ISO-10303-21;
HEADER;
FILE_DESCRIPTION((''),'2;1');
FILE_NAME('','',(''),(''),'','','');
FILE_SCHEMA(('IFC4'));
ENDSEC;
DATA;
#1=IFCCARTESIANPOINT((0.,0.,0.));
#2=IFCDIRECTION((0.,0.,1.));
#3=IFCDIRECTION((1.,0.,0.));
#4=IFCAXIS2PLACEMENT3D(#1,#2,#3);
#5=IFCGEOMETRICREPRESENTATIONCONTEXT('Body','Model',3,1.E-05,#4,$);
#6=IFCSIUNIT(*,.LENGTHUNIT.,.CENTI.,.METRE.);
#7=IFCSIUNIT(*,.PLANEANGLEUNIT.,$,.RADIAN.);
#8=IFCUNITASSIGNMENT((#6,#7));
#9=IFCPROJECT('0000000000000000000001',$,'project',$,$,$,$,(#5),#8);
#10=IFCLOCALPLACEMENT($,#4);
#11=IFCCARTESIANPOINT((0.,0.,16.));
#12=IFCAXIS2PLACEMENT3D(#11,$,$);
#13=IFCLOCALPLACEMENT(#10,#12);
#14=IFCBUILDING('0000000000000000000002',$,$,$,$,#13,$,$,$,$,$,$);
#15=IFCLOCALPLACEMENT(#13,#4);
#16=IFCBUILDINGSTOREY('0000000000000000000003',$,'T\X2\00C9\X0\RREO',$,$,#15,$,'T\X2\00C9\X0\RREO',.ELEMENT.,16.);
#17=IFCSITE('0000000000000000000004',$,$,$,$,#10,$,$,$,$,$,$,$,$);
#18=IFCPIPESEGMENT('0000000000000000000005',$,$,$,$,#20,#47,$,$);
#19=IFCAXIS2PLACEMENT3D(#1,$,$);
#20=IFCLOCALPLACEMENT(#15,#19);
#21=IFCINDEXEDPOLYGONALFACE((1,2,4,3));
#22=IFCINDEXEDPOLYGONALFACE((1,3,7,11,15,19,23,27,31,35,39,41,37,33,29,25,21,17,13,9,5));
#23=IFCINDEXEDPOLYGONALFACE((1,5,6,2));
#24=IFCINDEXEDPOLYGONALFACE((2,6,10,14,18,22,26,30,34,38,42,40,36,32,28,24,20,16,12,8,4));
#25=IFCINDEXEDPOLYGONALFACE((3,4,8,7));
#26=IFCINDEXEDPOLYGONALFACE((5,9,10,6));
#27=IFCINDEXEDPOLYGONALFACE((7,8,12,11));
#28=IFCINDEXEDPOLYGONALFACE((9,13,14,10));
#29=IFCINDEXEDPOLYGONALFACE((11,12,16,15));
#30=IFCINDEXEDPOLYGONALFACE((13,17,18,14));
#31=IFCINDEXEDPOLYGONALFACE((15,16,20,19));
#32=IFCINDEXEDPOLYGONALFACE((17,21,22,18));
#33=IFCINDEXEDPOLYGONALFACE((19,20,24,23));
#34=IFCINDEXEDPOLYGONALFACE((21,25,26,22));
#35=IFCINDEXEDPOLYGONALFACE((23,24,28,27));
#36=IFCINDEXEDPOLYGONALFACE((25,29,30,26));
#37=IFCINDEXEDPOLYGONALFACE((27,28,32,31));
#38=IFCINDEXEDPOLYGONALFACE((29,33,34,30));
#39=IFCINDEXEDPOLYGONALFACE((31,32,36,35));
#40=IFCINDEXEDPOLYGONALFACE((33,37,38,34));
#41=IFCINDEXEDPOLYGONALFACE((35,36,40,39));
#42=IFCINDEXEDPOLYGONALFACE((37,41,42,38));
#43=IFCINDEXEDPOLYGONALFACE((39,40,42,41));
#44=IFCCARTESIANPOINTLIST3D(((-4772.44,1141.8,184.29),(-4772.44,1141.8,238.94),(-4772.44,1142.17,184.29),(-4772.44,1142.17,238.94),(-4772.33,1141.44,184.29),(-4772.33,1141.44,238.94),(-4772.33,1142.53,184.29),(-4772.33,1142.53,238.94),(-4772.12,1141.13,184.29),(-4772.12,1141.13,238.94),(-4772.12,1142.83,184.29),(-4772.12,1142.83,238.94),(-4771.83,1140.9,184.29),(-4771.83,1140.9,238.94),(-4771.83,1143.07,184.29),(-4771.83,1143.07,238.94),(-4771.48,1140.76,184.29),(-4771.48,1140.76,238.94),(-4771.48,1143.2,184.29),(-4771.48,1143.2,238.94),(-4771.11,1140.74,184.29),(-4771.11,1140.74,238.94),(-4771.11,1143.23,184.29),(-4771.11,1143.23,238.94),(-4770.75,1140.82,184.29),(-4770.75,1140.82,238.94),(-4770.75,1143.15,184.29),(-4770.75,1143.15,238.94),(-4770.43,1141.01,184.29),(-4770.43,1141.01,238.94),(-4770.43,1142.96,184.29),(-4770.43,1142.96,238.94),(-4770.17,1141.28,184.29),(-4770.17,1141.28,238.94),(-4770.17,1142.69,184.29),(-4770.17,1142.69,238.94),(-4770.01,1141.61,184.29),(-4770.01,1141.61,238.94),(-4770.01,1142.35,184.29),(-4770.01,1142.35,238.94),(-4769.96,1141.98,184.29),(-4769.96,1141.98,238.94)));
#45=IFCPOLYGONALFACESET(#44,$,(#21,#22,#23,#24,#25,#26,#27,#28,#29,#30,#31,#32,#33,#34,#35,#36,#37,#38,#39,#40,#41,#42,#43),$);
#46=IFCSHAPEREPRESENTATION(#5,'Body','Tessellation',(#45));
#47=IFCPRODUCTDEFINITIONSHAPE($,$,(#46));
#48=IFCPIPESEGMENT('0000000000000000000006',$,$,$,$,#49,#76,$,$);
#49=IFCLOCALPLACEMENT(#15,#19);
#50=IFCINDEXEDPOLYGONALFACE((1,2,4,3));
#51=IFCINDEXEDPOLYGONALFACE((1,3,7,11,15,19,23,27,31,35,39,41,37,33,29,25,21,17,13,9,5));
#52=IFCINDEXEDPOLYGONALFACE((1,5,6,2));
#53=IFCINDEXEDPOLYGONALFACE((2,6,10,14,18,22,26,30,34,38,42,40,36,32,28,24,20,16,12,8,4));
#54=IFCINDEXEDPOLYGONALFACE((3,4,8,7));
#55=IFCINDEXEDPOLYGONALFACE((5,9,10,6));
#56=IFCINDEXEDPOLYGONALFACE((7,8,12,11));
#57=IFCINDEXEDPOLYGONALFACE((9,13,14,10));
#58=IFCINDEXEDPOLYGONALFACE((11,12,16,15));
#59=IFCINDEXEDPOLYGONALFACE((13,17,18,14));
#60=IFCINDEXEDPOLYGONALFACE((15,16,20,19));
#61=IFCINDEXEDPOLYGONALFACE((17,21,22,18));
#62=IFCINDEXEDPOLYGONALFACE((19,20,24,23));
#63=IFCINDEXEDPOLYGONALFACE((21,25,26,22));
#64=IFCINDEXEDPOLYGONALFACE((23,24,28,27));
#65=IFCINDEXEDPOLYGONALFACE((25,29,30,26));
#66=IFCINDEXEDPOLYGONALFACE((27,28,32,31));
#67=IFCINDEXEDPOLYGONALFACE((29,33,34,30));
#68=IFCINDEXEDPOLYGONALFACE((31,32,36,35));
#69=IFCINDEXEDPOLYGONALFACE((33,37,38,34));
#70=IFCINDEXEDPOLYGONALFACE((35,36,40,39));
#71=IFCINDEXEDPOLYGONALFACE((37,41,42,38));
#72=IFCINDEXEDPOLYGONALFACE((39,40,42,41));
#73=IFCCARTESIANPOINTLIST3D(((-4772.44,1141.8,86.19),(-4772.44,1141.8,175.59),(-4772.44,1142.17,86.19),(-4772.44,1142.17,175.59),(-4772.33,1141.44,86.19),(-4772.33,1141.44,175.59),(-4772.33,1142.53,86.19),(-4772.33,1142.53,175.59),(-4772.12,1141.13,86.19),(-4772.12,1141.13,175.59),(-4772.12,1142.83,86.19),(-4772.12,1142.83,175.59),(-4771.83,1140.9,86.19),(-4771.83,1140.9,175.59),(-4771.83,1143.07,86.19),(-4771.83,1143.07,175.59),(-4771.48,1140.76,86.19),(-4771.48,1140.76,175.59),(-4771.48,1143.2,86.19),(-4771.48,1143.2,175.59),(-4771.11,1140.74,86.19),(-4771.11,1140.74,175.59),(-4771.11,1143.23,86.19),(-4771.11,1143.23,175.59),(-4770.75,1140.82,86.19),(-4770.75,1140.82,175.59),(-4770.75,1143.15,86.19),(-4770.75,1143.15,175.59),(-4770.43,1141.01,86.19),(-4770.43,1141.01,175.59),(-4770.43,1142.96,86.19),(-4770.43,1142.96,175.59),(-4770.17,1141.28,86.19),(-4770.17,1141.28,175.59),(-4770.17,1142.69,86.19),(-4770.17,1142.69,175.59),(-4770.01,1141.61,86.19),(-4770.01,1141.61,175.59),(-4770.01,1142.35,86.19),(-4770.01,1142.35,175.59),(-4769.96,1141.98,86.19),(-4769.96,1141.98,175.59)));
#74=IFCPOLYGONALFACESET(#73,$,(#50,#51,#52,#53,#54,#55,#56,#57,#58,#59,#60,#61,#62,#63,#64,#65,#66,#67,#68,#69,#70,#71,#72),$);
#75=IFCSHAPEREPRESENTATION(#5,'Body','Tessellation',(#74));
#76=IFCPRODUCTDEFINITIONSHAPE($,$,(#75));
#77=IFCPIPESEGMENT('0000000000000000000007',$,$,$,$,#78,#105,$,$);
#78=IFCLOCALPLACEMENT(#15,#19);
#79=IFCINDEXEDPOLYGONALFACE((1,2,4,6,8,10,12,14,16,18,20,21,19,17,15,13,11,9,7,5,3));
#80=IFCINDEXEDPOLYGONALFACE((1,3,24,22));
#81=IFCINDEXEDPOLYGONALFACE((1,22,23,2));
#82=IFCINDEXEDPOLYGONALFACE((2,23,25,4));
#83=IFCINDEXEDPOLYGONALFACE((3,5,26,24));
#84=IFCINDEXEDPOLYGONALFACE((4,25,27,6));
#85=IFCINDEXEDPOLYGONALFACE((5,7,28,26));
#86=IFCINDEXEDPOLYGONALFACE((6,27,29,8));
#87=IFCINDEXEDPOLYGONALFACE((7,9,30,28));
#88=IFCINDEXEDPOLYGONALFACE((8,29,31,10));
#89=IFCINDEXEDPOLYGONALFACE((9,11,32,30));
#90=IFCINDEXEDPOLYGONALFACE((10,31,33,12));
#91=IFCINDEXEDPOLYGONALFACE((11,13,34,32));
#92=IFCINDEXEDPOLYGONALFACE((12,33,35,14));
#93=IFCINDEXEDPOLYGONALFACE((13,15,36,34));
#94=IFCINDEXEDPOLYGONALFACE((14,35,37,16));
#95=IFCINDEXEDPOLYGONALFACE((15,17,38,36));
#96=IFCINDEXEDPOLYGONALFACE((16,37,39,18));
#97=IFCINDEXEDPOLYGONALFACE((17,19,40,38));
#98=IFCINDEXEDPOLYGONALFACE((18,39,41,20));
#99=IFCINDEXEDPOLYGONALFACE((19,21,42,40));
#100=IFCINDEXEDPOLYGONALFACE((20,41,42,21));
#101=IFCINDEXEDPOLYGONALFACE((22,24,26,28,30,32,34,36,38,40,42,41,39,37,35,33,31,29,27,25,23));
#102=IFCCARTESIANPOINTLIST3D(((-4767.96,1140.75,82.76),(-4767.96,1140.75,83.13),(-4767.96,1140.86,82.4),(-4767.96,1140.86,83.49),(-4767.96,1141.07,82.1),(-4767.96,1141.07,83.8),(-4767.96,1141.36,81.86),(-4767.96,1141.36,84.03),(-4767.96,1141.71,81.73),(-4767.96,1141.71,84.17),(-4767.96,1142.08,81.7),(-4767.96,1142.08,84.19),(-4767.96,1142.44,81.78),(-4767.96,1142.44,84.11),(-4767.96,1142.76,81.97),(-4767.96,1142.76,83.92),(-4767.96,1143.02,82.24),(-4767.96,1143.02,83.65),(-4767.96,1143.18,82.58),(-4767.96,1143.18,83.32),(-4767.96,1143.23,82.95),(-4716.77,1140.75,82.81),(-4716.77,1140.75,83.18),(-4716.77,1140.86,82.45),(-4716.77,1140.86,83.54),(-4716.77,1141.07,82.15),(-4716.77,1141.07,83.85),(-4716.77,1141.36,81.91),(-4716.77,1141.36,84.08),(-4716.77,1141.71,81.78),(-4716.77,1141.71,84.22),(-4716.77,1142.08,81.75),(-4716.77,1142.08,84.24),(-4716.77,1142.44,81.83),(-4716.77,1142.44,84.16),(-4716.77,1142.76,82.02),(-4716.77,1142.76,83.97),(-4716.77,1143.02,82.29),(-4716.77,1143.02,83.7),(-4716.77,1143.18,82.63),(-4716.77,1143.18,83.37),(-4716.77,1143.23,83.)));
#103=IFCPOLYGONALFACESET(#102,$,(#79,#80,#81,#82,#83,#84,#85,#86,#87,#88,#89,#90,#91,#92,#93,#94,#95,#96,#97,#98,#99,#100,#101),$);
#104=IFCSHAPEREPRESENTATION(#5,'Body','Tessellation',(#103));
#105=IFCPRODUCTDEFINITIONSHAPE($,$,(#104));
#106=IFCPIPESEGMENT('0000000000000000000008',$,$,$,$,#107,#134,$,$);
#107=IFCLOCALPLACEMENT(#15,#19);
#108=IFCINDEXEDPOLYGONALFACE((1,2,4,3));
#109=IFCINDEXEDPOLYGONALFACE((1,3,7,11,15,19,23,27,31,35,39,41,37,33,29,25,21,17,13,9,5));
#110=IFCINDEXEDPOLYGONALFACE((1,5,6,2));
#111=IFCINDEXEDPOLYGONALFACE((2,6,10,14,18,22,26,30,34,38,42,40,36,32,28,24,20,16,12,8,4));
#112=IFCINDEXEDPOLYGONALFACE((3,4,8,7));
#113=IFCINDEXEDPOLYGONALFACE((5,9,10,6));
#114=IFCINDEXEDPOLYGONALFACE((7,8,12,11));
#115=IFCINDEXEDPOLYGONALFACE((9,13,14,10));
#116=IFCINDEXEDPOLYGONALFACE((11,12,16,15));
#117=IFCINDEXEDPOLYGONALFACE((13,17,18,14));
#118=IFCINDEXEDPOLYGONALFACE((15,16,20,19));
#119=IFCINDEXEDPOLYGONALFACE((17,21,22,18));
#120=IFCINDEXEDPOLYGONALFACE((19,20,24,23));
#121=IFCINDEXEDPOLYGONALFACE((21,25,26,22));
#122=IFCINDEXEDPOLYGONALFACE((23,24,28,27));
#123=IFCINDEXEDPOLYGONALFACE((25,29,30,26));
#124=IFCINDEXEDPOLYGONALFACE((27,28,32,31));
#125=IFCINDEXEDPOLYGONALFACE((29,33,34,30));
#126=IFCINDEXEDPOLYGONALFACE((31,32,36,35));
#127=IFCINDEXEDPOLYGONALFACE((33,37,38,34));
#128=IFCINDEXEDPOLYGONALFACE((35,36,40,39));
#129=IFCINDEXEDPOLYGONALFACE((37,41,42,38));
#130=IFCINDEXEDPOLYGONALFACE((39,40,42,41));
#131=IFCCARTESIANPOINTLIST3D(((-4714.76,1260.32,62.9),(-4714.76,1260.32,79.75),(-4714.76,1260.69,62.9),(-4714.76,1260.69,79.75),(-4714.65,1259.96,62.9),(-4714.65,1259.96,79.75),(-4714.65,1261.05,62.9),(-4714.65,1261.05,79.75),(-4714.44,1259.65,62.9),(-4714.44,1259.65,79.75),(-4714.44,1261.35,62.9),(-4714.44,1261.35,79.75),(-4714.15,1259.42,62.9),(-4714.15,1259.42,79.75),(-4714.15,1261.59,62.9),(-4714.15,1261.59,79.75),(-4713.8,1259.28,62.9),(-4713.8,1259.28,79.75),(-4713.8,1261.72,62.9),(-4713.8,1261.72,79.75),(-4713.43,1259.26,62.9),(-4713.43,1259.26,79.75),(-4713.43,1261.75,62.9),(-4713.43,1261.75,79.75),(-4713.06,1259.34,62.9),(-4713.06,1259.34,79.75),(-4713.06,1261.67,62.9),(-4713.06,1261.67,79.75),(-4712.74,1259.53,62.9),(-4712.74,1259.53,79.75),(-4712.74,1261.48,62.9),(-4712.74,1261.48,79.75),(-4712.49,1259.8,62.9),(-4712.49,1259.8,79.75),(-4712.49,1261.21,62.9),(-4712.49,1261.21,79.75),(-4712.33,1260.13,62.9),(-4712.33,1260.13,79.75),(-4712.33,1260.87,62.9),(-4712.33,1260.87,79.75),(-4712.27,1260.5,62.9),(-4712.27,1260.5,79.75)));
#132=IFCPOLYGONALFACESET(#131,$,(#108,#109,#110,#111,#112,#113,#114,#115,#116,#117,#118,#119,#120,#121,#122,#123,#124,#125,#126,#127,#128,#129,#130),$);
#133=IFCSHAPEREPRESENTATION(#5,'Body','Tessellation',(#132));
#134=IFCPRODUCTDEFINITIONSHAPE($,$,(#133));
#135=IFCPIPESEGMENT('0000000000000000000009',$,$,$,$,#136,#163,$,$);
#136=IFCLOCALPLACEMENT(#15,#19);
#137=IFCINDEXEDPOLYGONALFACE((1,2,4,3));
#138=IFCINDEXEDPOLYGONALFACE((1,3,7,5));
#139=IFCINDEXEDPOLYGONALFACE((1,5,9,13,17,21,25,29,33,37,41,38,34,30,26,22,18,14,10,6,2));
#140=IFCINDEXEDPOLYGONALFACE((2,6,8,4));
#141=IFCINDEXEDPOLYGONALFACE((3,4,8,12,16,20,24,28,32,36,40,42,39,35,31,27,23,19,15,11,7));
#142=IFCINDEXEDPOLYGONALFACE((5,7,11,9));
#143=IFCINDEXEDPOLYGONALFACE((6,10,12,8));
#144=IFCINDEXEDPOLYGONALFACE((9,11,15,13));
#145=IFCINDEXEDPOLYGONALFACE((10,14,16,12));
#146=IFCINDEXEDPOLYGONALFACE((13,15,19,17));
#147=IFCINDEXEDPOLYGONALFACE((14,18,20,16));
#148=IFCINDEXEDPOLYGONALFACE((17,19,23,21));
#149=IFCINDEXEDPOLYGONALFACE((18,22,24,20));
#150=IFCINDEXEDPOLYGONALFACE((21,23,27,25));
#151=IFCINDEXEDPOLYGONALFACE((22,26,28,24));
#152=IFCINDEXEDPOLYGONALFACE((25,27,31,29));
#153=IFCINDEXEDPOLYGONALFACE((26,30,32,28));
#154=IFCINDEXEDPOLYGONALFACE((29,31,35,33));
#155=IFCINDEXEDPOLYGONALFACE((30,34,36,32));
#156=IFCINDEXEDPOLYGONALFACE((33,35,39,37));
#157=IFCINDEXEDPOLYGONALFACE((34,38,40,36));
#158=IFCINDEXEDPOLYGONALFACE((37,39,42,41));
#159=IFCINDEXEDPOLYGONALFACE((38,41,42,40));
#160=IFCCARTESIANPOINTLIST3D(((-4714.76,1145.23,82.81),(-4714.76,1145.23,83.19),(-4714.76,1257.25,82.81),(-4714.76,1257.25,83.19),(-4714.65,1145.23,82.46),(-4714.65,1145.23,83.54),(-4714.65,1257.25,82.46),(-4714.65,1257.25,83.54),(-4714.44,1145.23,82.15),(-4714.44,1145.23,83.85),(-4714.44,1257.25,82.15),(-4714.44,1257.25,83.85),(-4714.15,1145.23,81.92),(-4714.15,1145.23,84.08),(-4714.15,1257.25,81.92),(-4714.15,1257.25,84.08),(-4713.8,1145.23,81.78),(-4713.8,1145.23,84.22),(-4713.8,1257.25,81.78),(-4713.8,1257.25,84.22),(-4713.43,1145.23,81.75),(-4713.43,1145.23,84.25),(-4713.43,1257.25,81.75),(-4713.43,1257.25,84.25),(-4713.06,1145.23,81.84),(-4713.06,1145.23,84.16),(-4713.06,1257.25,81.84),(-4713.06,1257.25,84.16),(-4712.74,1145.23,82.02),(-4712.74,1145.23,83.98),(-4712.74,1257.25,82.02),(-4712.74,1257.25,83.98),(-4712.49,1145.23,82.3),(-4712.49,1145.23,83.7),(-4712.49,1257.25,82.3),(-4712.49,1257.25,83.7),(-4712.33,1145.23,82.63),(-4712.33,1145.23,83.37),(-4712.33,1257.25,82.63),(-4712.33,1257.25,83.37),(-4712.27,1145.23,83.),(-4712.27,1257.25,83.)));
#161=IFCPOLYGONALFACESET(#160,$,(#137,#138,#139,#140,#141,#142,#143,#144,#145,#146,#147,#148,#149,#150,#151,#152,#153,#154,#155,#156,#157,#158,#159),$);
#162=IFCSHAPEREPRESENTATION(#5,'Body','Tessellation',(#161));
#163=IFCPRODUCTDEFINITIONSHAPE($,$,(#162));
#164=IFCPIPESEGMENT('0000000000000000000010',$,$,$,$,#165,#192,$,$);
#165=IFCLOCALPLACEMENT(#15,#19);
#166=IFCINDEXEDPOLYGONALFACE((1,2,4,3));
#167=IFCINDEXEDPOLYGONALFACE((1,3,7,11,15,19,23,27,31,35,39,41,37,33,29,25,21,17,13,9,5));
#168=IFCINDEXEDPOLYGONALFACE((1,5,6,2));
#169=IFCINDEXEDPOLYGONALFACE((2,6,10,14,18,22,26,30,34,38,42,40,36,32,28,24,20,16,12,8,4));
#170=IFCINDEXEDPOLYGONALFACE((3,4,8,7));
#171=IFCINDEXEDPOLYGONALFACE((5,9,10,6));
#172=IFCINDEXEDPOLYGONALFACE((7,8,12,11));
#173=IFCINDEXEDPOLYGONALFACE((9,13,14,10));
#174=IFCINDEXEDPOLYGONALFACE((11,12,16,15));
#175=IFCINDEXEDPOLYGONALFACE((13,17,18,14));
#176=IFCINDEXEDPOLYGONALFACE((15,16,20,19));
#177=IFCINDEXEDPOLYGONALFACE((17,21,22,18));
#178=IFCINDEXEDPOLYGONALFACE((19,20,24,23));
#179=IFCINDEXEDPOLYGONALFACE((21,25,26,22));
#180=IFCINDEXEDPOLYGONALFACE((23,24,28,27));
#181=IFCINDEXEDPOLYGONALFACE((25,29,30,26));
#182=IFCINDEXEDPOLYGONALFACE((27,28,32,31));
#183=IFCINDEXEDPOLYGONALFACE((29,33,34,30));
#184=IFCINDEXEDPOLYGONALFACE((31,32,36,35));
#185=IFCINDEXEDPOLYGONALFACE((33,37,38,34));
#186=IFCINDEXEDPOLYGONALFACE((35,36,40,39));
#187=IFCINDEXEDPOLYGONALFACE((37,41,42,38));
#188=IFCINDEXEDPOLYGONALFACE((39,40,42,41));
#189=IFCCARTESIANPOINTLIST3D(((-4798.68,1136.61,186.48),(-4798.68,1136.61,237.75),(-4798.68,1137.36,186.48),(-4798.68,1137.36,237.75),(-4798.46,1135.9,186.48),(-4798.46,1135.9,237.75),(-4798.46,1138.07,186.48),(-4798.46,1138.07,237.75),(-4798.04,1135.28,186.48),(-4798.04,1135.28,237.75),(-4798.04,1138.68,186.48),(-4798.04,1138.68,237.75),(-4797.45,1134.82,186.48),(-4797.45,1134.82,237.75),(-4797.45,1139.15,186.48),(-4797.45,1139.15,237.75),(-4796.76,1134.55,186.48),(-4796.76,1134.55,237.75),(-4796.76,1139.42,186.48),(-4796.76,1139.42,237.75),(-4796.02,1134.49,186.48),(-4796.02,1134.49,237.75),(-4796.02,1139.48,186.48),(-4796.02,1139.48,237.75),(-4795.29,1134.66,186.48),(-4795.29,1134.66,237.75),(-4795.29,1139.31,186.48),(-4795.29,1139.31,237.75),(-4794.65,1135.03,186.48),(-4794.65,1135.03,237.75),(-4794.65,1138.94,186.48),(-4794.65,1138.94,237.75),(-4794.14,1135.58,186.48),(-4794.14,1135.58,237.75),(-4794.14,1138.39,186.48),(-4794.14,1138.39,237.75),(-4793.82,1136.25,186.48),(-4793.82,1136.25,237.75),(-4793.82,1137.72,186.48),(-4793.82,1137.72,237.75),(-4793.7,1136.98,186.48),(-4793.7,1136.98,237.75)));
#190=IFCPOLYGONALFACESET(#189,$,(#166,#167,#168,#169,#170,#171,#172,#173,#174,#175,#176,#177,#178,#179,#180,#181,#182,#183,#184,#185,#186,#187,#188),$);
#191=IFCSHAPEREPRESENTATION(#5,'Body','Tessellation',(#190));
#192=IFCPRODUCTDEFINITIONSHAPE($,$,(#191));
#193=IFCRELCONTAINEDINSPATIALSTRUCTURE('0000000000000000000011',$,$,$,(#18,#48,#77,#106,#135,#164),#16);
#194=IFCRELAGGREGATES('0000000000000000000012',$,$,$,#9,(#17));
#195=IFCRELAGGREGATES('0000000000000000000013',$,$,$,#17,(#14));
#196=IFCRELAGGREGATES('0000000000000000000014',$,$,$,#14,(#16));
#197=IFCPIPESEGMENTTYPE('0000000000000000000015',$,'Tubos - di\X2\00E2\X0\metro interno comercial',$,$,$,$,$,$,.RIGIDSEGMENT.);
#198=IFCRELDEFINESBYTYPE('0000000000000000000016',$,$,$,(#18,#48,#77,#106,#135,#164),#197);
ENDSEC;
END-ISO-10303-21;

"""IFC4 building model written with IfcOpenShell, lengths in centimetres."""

from ifc_helpers import new_model, si_unit, frame, origin_with_axes, origin_2d_with_axis, place, context, project, spatial, circle, extrude, type_object, element, save


model = new_model("IFC4")

# Units and contexts
model_context = context("Model", 3, precision=1e-05, world=origin_with_axes(), identifier="Body")
ifc_project = project(units=[si_unit("LENGTHUNIT", "METRE", prefix="CENTI"), si_unit("PLANEANGLEUNIT", "RADIAN")], contexts=[model_context])

# Site, building, storey
site_placement = place(None, origin_with_axes())
site = spatial("IfcSite", under=ifc_project, at=site_placement)
building_placement = place(site_placement, frame((0.0, 0.0, 16.0)))
building = spatial("IfcBuilding", under=site, at=building_placement)
storey_placement = place(building_placement, origin_with_axes())
storey = spatial("IfcBuildingStorey", under=building, at=storey_placement, Name="TÉRREO", LongName="TÉRREO", CompositionType="ELEMENT", Elevation=16.0)

# Pipe segments
pipe_segment_type = type_object("IfcPipeSegmentType", Name="Tubos - diâmetro interno comercial", PredefinedType="RIGIDSEGMENT")
pipe_segment_1_placement = place(storey_placement, frame((-4771.21, 1141.98, 238.94), z_axis=(0.0, 0.0, 1.0), x_axis=(1.0, 0.0, 0.0)))
element("IfcPipeSegment", 1, at=pipe_segment_1_placement, inside=storey, type_object=pipe_segment_type, context=model_context, shape_type="SolidModel", body=[
    extrude(circle(Radius=1.25, at=origin_2d_with_axis()), frame((0.0, 0.0, 0.0), z_axis=(0.0, 0.0, -1.0), x_axis=(1.0, 0.0, 0.0)), (0.0, 0.0, 1.0), 54.65),
])
pipe_segment_2_placement = place(storey_placement, frame((-4771.21, 1141.98, 175.59), z_axis=(0.0, 0.0, 1.0), x_axis=(1.0, 0.0, 0.0)))
element("IfcPipeSegment", 2, at=pipe_segment_2_placement, inside=storey, type_object=pipe_segment_type, context=model_context, shape_type="SolidModel", body=[
    extrude(circle(Radius=1.25, at=origin_2d_with_axis()), frame((0.0, 0.0, 0.0), z_axis=(0.0, 0.0, -1.0), x_axis=(1.0, 0.0, 0.0)), (0.0, 0.0, 1.0), 89.4),
])
pipe_segment_3_placement = place(storey_placement, frame((-4742.36, 1141.98, 84.25), z_axis=(0.0, 0.0, 1.0), x_axis=(1.0, 0.0, 0.0)))
element("IfcPipeSegment", 3, at=pipe_segment_3_placement, inside=storey, type_object=pipe_segment_type, context=model_context, shape_type="SolidModel", body=[
    extrude(circle(Radius=1.25, at=origin_2d_with_axis()), frame((-25.59, 0.0, -1.3), z_axis=(1.0, 0.0, 0.000979), x_axis=(0.0, 1.0, 0.0)), (0.0, 0.0, 1.0), 51.19),
])
pipe_segment_4_placement = place(storey_placement, frame((-4713.52, 1260.5, 79.75), z_axis=(0.0, 0.0, 1.0), x_axis=(1.0, 0.0, 0.0)))
element("IfcPipeSegment", 4, at=pipe_segment_4_placement, inside=storey, type_object=pipe_segment_type, context=model_context, shape_type="SolidModel", body=[
    extrude(circle(Radius=1.25, at=origin_2d_with_axis()), frame((0.0, 0.0, 0.0), z_axis=(0.0, 0.0, -1.0), x_axis=(1.0, 0.0, 0.0)), (0.0, 0.0, 1.0), 16.85),
])
pipe_segment_5_placement = place(storey_placement, frame((-4713.52, 1201.24, 84.25), z_axis=(0.0, 0.0, 1.0), x_axis=(1.0, 0.0, 0.0)))
element("IfcPipeSegment", 5, at=pipe_segment_5_placement, inside=storey, type_object=pipe_segment_type, context=model_context, shape_type="SolidModel", body=[
    extrude(circle(Radius=1.25, at=origin_2d_with_axis()), frame((0.0, -56.01, -1.25), z_axis=(0.0, 1.0, 0.0), x_axis=(1.0, 0.0, 0.0)), (0.0, 0.0, 1.0), 112.02),
])
pipe_segment_6_placement = place(storey_placement, frame((-4796.2, 1136.98, 237.75), z_axis=(0.0, 0.0, 1.0), x_axis=(1.0, 0.0, 0.0)))
element("IfcPipeSegment", 6, at=pipe_segment_6_placement, inside=storey, type_object=pipe_segment_type, context=model_context, shape_type="SolidModel", body=[
    extrude(circle(Radius=2.5, at=origin_2d_with_axis()), frame((0.0, 0.0, 0.0), z_axis=(0.0, 0.0, -1.0), x_axis=(1.0, 0.0, 0.0)), (0.0, 0.0, 1.0), 51.27),
])

save(model, "model.ifc")
